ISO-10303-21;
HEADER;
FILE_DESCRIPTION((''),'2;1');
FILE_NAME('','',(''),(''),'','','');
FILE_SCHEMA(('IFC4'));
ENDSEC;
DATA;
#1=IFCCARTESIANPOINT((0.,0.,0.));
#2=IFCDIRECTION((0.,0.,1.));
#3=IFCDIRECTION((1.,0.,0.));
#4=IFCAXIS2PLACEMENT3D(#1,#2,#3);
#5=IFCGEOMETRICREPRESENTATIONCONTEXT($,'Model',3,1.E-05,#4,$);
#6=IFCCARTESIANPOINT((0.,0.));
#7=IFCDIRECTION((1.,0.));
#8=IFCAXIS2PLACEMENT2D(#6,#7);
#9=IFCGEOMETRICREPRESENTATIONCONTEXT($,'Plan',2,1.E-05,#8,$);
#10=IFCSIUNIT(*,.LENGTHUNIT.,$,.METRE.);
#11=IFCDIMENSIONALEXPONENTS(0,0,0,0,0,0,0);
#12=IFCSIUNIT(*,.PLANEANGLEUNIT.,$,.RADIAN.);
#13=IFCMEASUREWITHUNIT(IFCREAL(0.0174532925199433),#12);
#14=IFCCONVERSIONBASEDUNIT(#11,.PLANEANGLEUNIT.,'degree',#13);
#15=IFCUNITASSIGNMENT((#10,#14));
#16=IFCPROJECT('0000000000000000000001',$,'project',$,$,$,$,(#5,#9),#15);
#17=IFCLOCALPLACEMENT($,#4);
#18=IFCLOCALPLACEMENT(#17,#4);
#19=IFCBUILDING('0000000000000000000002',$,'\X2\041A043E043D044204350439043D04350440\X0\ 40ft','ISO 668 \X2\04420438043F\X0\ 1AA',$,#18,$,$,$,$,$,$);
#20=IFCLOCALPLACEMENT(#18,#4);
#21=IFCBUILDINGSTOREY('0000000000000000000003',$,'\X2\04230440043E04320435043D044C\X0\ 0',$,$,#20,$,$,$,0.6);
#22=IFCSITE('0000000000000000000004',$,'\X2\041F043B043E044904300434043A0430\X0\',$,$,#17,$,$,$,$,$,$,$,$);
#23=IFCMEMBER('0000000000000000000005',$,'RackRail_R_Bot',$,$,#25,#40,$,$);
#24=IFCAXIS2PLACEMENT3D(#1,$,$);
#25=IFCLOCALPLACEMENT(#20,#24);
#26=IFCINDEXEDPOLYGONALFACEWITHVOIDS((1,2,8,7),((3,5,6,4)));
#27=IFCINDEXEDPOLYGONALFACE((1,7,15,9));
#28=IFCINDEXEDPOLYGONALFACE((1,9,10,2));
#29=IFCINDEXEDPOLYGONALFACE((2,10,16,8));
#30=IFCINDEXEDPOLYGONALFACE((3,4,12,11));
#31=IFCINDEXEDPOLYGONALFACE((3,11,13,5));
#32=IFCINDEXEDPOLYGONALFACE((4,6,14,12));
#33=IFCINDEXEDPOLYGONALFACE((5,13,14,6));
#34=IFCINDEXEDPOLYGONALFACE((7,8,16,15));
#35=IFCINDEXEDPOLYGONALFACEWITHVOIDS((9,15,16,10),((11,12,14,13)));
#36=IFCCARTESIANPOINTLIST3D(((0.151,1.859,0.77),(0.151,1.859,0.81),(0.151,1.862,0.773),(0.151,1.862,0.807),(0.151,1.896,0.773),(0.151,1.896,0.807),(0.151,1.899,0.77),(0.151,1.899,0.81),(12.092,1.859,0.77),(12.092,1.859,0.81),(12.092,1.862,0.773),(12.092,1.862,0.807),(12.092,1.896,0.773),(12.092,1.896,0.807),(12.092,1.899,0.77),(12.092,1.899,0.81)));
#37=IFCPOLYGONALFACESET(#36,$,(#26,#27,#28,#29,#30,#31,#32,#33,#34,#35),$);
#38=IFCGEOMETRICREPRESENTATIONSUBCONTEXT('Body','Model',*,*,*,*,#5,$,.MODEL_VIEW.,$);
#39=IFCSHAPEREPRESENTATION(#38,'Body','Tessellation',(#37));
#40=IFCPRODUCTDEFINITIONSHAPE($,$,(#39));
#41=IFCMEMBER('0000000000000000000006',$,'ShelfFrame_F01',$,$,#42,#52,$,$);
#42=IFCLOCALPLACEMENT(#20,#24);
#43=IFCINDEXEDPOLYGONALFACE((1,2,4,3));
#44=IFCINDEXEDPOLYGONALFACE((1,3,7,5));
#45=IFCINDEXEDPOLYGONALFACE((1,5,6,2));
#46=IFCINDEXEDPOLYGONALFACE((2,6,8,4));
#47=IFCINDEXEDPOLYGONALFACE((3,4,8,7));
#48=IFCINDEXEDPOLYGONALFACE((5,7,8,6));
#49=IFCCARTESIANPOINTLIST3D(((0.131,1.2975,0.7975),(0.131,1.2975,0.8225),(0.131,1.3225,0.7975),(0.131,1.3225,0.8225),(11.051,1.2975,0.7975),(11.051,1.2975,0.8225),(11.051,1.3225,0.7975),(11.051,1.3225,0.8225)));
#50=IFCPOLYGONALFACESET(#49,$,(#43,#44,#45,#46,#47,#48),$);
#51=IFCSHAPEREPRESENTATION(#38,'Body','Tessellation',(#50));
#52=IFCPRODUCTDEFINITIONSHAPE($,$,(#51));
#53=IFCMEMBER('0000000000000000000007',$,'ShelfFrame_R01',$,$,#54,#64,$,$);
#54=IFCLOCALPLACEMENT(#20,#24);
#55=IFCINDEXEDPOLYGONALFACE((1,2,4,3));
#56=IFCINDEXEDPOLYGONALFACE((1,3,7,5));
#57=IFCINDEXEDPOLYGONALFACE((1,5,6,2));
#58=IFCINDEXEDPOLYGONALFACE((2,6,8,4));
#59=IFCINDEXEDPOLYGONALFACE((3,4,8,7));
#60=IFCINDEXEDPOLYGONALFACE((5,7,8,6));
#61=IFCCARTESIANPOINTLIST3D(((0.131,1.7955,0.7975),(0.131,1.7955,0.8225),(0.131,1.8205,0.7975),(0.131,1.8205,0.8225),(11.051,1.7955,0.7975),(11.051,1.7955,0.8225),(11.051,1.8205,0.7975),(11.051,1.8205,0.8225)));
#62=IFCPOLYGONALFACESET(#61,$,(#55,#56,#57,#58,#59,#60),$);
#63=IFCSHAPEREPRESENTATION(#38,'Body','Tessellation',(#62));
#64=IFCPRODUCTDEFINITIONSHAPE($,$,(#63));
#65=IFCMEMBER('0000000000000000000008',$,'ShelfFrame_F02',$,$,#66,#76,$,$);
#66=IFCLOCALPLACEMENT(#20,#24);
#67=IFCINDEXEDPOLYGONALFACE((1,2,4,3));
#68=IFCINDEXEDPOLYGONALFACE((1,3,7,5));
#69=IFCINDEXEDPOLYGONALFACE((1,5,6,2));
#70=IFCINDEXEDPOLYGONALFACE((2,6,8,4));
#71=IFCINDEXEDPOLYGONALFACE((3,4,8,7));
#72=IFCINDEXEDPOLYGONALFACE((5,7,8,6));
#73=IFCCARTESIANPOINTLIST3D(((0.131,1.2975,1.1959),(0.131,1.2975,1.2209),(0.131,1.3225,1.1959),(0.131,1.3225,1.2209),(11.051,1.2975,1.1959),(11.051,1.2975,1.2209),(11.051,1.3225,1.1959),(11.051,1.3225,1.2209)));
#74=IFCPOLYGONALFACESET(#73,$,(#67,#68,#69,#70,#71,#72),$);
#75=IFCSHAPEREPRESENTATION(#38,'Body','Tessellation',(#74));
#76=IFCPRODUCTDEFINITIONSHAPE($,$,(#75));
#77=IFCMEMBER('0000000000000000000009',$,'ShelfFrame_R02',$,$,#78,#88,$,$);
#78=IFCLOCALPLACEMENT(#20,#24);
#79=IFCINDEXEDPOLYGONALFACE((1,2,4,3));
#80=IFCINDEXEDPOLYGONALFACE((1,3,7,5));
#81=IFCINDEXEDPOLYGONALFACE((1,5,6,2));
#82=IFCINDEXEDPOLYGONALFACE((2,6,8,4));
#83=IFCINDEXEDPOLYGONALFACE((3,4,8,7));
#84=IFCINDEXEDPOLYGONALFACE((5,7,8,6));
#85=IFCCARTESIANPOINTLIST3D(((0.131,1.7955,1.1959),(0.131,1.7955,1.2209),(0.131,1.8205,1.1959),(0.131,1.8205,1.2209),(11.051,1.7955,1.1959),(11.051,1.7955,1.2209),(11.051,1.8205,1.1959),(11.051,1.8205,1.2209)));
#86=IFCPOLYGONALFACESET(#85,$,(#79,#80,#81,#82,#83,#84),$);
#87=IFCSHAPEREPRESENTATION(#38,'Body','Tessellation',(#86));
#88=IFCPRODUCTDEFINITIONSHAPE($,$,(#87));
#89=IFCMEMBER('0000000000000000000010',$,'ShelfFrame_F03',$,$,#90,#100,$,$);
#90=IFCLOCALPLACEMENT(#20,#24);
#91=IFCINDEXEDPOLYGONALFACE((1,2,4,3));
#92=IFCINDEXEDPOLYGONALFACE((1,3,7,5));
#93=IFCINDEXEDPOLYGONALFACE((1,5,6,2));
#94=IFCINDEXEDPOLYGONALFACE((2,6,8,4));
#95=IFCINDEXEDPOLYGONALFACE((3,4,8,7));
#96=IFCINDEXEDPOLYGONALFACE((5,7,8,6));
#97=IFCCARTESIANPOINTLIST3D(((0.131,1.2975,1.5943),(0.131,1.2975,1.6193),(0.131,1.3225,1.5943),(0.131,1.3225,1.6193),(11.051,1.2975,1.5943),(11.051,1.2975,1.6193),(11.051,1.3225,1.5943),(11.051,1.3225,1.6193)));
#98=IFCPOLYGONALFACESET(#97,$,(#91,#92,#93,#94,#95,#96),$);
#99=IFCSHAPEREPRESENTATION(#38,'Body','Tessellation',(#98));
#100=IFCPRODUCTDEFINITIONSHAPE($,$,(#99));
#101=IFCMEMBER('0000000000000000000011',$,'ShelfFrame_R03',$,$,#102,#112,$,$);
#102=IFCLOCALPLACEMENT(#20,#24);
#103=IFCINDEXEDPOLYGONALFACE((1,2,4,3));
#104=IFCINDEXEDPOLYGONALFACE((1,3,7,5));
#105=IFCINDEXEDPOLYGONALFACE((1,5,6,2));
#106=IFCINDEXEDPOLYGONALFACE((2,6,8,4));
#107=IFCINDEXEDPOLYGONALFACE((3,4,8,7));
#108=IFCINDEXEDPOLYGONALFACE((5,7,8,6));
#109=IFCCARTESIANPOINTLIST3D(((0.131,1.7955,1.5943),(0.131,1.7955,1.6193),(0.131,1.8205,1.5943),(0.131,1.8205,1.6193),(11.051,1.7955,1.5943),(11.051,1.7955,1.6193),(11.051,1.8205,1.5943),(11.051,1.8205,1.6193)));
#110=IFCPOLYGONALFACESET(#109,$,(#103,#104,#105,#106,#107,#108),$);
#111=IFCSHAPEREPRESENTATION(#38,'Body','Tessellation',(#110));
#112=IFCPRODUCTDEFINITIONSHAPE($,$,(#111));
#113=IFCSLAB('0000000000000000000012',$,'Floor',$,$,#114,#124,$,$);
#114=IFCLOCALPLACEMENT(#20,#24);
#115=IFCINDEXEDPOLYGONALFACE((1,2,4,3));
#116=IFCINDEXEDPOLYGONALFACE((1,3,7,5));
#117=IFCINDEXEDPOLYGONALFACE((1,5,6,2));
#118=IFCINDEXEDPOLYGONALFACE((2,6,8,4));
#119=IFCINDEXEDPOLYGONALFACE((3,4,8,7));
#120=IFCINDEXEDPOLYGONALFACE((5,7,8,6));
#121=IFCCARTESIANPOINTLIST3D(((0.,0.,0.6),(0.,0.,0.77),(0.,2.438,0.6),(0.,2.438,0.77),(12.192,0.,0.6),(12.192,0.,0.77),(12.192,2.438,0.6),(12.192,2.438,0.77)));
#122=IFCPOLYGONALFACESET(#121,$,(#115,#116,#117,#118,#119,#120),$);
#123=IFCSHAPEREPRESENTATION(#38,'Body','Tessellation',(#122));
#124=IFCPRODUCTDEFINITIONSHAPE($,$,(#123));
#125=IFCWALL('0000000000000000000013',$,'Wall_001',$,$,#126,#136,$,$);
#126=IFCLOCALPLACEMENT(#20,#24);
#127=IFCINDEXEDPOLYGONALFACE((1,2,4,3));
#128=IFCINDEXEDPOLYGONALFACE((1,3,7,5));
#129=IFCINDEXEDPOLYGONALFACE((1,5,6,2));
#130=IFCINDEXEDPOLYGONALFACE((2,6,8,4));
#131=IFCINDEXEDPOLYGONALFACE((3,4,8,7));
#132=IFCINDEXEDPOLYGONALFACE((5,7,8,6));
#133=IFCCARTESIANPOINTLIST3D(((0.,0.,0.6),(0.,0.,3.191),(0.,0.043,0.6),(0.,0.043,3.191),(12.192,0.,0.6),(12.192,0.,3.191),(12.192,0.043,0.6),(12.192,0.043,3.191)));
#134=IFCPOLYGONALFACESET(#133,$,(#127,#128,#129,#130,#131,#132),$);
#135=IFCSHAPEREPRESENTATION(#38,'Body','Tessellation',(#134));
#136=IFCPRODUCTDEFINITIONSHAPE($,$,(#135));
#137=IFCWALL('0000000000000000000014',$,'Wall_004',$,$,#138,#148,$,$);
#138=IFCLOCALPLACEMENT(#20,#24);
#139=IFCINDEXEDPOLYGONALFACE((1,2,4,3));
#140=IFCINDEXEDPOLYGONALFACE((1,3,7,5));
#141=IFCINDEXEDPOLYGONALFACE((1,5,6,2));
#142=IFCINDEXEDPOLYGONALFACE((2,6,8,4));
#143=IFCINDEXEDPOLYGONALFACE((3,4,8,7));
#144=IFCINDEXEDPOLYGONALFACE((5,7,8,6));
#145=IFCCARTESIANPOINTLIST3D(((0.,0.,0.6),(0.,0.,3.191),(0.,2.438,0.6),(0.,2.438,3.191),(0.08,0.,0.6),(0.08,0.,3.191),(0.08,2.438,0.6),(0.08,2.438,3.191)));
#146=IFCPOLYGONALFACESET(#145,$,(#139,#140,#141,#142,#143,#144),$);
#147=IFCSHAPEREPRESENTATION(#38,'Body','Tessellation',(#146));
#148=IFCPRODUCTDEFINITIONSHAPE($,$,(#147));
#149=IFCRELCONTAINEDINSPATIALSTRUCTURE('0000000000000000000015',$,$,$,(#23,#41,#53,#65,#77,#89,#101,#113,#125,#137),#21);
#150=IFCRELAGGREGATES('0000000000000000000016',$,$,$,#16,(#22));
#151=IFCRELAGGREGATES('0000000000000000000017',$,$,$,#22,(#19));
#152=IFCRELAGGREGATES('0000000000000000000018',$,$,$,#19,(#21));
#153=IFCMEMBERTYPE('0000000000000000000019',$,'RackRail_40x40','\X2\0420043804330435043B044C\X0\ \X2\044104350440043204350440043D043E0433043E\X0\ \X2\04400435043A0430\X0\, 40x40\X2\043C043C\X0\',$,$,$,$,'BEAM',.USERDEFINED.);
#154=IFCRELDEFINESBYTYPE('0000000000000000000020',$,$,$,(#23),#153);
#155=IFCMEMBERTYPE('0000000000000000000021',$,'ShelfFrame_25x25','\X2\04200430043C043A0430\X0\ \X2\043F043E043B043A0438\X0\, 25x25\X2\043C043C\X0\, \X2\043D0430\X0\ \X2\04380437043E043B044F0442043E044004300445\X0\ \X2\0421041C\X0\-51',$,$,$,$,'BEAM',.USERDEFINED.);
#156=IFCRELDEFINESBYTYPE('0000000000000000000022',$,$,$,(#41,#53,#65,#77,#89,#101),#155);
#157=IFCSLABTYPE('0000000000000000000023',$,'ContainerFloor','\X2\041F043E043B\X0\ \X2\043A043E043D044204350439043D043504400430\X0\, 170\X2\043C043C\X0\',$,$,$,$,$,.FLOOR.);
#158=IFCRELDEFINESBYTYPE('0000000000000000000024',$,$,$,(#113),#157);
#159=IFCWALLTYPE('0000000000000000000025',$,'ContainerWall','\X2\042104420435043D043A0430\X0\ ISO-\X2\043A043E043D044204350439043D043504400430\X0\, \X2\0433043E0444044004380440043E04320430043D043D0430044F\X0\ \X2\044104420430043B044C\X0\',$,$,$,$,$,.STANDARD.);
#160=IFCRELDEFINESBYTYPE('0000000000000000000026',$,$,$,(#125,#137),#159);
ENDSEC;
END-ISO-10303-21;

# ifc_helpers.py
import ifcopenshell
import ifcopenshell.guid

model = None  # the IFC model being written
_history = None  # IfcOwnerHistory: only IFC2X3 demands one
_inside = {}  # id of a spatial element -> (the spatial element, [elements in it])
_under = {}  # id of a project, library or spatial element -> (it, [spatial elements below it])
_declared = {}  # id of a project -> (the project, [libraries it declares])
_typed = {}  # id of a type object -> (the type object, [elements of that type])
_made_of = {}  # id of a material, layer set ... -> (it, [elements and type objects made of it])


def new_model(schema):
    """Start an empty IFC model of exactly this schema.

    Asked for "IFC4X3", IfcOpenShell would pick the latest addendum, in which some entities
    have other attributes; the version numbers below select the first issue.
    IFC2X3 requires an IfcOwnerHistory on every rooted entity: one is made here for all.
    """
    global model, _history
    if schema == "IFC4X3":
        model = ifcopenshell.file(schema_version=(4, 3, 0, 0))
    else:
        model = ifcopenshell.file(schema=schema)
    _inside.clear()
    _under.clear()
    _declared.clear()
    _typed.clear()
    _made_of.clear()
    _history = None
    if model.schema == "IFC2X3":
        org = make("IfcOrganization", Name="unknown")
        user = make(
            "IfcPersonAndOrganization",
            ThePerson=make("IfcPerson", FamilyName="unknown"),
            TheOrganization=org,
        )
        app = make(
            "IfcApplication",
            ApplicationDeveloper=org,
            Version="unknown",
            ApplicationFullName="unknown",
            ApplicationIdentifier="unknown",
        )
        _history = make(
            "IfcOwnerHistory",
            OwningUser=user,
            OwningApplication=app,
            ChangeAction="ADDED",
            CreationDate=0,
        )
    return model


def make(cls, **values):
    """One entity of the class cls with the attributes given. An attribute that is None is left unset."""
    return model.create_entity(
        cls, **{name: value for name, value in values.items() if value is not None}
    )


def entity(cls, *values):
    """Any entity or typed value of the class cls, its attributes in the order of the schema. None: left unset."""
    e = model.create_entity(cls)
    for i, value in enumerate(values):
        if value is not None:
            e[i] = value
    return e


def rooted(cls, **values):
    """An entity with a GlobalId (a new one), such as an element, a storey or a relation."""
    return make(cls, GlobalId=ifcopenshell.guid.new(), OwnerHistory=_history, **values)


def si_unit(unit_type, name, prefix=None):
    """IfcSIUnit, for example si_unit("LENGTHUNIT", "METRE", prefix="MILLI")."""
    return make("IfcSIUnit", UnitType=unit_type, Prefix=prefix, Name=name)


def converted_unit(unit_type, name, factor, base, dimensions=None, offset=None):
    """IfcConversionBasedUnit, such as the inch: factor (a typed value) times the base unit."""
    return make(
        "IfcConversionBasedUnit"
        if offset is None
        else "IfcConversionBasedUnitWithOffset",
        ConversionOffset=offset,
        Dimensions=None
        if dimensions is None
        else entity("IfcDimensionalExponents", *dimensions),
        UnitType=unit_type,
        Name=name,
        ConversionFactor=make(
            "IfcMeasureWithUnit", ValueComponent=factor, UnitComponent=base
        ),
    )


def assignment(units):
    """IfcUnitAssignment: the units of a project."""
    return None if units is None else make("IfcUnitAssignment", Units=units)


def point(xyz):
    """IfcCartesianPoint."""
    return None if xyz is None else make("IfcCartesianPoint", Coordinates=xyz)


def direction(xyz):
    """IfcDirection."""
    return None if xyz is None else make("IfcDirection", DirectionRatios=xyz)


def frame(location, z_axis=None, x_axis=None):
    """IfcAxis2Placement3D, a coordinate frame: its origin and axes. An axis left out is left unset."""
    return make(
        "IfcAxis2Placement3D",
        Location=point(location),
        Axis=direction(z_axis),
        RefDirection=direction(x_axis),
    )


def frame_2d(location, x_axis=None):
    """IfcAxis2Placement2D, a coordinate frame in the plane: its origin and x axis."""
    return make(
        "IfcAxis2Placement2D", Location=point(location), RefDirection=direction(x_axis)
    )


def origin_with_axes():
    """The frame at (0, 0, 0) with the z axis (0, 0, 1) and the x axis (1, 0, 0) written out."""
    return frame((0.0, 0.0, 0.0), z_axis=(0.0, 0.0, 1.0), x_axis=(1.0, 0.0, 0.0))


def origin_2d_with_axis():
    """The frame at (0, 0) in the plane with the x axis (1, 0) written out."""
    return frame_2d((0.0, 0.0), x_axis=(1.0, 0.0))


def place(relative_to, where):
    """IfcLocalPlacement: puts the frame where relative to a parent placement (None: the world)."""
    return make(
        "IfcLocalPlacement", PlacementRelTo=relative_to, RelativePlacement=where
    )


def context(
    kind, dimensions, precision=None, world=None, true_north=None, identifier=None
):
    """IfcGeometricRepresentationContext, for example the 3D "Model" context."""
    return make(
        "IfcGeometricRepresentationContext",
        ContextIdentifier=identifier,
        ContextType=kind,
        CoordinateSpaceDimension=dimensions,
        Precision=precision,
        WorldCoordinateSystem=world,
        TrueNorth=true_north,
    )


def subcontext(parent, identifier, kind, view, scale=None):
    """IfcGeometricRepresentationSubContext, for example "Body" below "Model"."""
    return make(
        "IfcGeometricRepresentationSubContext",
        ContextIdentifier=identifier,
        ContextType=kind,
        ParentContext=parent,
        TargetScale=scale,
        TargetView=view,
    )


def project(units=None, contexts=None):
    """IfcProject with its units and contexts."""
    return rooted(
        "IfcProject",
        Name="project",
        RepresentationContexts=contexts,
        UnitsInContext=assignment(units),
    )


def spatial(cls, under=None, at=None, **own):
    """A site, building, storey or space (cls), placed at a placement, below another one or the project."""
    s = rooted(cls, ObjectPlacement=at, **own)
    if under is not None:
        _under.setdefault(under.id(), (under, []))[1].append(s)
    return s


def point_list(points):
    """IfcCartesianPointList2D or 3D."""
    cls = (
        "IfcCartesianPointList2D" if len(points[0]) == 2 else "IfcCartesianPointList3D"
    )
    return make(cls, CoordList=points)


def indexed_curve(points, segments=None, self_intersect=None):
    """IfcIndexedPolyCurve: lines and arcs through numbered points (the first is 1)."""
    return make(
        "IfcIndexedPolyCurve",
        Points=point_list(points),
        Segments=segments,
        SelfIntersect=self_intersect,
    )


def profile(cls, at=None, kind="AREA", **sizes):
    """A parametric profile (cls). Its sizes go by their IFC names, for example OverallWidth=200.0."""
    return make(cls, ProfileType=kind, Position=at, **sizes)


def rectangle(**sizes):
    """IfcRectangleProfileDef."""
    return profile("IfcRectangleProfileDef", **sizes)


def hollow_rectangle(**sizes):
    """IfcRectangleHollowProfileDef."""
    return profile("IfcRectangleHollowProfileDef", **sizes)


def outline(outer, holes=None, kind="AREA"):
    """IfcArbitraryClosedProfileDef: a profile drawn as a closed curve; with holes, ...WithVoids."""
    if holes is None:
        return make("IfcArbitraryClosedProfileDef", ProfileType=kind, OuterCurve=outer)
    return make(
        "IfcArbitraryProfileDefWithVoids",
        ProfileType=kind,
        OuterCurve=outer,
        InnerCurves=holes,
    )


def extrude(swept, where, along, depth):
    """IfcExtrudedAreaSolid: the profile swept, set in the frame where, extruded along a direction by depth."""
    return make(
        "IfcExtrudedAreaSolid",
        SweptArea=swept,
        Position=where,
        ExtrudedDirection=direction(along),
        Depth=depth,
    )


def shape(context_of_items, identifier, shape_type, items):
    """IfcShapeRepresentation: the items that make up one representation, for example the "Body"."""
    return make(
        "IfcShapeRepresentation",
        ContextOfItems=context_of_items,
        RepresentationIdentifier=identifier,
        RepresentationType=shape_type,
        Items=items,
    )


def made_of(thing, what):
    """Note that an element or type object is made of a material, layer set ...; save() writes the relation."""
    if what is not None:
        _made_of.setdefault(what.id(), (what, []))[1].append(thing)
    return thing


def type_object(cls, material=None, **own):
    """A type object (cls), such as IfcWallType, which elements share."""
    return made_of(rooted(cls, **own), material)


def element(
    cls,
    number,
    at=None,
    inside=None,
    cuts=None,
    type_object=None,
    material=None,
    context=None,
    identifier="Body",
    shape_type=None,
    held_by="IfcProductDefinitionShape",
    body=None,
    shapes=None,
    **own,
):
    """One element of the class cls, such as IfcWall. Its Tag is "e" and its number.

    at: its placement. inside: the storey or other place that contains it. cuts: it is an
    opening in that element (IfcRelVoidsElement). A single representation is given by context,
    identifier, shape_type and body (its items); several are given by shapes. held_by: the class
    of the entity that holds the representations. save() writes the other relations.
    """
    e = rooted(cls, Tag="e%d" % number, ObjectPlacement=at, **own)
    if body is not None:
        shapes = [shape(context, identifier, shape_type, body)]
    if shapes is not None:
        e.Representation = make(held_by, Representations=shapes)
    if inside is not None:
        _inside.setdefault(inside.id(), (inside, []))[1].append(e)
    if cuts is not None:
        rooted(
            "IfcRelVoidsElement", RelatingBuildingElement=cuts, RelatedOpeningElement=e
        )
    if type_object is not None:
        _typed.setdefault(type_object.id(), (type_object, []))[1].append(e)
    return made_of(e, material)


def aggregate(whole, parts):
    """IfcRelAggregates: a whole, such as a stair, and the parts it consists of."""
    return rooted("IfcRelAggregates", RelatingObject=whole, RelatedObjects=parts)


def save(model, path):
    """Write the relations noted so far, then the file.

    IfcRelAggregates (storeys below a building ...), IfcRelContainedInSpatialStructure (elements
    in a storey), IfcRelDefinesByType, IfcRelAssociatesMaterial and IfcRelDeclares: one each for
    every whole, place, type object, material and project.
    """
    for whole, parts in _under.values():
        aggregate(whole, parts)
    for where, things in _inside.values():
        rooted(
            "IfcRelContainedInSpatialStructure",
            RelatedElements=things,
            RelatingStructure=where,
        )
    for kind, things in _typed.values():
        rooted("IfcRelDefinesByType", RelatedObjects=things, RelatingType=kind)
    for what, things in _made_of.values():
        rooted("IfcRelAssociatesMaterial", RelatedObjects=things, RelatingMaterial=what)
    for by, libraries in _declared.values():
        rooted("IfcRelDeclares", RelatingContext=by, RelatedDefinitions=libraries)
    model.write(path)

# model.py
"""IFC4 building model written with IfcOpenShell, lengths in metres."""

from ifc_helpers import new_model, entity, si_unit, converted_unit, frame, origin_with_axes, origin_2d_with_axis, place, context, subcontext, project, spatial, indexed_curve, rectangle, hollow_rectangle, outline, extrude, type_object, element, save


model = new_model("IFC4")

# Units and contexts
model_context = context("Model", 3, precision=1e-05, world=origin_with_axes())
plan_context = context("Plan", 2, precision=1e-05, world=origin_2d_with_axis())
body_context = subcontext(model_context, "Body", "Model", "MODEL_VIEW")
ifc_project = project(units=[si_unit("LENGTHUNIT", "METRE"), converted_unit("PLANEANGLEUNIT", "degree", entity("IfcReal", 0.0174532925199433), si_unit("PLANEANGLEUNIT", "RADIAN"), dimensions=[0, 0, 0, 0, 0, 0, 0])], contexts=[model_context, plan_context])

# Site, building, storey
site_placement = place(None, origin_with_axes())
site = spatial("IfcSite", under=ifc_project, at=site_placement, Name="Площадка")
building_placement = place(site_placement, origin_with_axes())
building = spatial("IfcBuilding", under=site, at=building_placement, Name="Контейнер 40ft", Description="ISO 668 тип 1AA")
storey_placement = place(building_placement, origin_with_axes())
storey = spatial("IfcBuildingStorey", under=building, at=storey_placement, Name="Уровень 0", Elevation=0.6)

# Members
member_type_1 = type_object("IfcMemberType", Name="RackRail_40x40", Description="Ригель серверного река, 40x40мм", ElementType="BEAM", PredefinedType="USERDEFINED")
for number, where, z_axis, x_axis, name in (
    (1, (0.151, 1.879, 0.79), (1.0, 0.0, 0.0), (0.0, 1.0, 0.0), "RackRail_R_Bot"),
):
    element("IfcMember", number, at=place(storey_placement, frame(where, z_axis=z_axis, x_axis=x_axis)), inside=storey, type_object=member_type_1, Name=name, context=body_context, shape_type="SweptSolid", body=[
        extrude(hollow_rectangle(XDim=0.04, YDim=0.04, WallThickness=0.003), origin_with_axes(), (0.0, 0.0, 1.0), 11.941),
    ])
member_type_2 = type_object("IfcMemberType", Name="ShelfFrame_25x25", Description="Рамка полки, 25x25мм, на изоляторах СМ-51", ElementType="BEAM", PredefinedType="USERDEFINED")
for number, where, z_axis, x_axis, name in (
    (2, (0.131, 1.31, 0.81), (1.0, 0.0, 0.0), (0.0, 1.0, 0.0), "ShelfFrame_F01"),
    (3, (0.131, 1.808, 0.81), (1.0, 0.0, 0.0), (0.0, 1.0, 0.0), "ShelfFrame_R01"),
    (4, (0.131, 1.31, 1.2084), (1.0, 0.0, 0.0), (0.0, 1.0, 0.0), "ShelfFrame_F02"),
    (5, (0.131, 1.808, 1.2084), (1.0, 0.0, 0.0), (0.0, 1.0, 0.0), "ShelfFrame_R02"),
    (6, (0.131, 1.31, 1.6068), (1.0, 0.0, 0.0), (0.0, 1.0, 0.0), "ShelfFrame_F03"),
    (7, (0.131, 1.808, 1.6068), (1.0, 0.0, 0.0), (0.0, 1.0, 0.0), "ShelfFrame_R03"),
):
    element("IfcMember", number, at=place(storey_placement, frame(where, z_axis=z_axis, x_axis=x_axis)), inside=storey, type_object=member_type_2, Name=name, context=body_context, shape_type="SweptSolid", body=[
        extrude(rectangle(XDim=0.025, YDim=0.025), origin_with_axes(), (0.0, 0.0, 1.0), 10.92),
    ])

# Slab
slab_type = type_object("IfcSlabType", Name="ContainerFloor", Description="Пол контейнера, 170мм", PredefinedType="FLOOR")
slab_placement = place(storey_placement, frame((0.0, 0.0, 0.6), z_axis=(0.0, 0.0, 1.0), x_axis=(1.0, 0.0, 0.0)))
element("IfcSlab", 8, at=slab_placement, inside=storey, type_object=slab_type, Name="Floor", context=body_context, shape_type="SweptSolid", body=[
    extrude(outline(indexed_curve([(0.0, 0.0), (12.192, 0.0), (12.192, 2.438), (0.0, 2.438)])), None, (0.0, 0.0, 1.0), 0.17),
])

# Walls
wall_type = type_object("IfcWallType", Name="ContainerWall", Description="Стенка ISO-контейнера, гофрированная сталь", PredefinedType="STANDARD")
wall_1_placement = place(storey_placement, frame((0.0, 0.0, 0.6), z_axis=(0.0, 0.0, 1.0), x_axis=(1.0, 0.0, 0.0)))
element("IfcWall", 9, at=wall_1_placement, inside=storey, type_object=wall_type, Name="Wall_001", context=body_context, shape_type="SweptSolid", body=[
    extrude(outline(indexed_curve([(0.0, 0.0), (0.0, 0.043), (12.192, 0.043), (12.192, 0.0), (0.0, 0.0)], self_intersect=False)), origin_with_axes(), (0.0, 0.0, 1.0), 2.591),
])
wall_2_placement = place(storey_placement, frame((0.0, 2.438, 0.6), z_axis=(0.0, 0.0, 1.0), x_axis=(0.0, -1.0, 0.0)))
element("IfcWall", 10, at=wall_2_placement, inside=storey, type_object=wall_type, Name="Wall_004", context=body_context, shape_type="SweptSolid", body=[
    extrude(outline(indexed_curve([(0.0, 0.0), (0.0, 0.08), (2.438, 0.08), (2.438, 0.0), (0.0, 0.0)], self_intersect=False)), origin_with_axes(), (0.0, 0.0, 1.0), 2.591),
])

save(model, "model.ifc")
